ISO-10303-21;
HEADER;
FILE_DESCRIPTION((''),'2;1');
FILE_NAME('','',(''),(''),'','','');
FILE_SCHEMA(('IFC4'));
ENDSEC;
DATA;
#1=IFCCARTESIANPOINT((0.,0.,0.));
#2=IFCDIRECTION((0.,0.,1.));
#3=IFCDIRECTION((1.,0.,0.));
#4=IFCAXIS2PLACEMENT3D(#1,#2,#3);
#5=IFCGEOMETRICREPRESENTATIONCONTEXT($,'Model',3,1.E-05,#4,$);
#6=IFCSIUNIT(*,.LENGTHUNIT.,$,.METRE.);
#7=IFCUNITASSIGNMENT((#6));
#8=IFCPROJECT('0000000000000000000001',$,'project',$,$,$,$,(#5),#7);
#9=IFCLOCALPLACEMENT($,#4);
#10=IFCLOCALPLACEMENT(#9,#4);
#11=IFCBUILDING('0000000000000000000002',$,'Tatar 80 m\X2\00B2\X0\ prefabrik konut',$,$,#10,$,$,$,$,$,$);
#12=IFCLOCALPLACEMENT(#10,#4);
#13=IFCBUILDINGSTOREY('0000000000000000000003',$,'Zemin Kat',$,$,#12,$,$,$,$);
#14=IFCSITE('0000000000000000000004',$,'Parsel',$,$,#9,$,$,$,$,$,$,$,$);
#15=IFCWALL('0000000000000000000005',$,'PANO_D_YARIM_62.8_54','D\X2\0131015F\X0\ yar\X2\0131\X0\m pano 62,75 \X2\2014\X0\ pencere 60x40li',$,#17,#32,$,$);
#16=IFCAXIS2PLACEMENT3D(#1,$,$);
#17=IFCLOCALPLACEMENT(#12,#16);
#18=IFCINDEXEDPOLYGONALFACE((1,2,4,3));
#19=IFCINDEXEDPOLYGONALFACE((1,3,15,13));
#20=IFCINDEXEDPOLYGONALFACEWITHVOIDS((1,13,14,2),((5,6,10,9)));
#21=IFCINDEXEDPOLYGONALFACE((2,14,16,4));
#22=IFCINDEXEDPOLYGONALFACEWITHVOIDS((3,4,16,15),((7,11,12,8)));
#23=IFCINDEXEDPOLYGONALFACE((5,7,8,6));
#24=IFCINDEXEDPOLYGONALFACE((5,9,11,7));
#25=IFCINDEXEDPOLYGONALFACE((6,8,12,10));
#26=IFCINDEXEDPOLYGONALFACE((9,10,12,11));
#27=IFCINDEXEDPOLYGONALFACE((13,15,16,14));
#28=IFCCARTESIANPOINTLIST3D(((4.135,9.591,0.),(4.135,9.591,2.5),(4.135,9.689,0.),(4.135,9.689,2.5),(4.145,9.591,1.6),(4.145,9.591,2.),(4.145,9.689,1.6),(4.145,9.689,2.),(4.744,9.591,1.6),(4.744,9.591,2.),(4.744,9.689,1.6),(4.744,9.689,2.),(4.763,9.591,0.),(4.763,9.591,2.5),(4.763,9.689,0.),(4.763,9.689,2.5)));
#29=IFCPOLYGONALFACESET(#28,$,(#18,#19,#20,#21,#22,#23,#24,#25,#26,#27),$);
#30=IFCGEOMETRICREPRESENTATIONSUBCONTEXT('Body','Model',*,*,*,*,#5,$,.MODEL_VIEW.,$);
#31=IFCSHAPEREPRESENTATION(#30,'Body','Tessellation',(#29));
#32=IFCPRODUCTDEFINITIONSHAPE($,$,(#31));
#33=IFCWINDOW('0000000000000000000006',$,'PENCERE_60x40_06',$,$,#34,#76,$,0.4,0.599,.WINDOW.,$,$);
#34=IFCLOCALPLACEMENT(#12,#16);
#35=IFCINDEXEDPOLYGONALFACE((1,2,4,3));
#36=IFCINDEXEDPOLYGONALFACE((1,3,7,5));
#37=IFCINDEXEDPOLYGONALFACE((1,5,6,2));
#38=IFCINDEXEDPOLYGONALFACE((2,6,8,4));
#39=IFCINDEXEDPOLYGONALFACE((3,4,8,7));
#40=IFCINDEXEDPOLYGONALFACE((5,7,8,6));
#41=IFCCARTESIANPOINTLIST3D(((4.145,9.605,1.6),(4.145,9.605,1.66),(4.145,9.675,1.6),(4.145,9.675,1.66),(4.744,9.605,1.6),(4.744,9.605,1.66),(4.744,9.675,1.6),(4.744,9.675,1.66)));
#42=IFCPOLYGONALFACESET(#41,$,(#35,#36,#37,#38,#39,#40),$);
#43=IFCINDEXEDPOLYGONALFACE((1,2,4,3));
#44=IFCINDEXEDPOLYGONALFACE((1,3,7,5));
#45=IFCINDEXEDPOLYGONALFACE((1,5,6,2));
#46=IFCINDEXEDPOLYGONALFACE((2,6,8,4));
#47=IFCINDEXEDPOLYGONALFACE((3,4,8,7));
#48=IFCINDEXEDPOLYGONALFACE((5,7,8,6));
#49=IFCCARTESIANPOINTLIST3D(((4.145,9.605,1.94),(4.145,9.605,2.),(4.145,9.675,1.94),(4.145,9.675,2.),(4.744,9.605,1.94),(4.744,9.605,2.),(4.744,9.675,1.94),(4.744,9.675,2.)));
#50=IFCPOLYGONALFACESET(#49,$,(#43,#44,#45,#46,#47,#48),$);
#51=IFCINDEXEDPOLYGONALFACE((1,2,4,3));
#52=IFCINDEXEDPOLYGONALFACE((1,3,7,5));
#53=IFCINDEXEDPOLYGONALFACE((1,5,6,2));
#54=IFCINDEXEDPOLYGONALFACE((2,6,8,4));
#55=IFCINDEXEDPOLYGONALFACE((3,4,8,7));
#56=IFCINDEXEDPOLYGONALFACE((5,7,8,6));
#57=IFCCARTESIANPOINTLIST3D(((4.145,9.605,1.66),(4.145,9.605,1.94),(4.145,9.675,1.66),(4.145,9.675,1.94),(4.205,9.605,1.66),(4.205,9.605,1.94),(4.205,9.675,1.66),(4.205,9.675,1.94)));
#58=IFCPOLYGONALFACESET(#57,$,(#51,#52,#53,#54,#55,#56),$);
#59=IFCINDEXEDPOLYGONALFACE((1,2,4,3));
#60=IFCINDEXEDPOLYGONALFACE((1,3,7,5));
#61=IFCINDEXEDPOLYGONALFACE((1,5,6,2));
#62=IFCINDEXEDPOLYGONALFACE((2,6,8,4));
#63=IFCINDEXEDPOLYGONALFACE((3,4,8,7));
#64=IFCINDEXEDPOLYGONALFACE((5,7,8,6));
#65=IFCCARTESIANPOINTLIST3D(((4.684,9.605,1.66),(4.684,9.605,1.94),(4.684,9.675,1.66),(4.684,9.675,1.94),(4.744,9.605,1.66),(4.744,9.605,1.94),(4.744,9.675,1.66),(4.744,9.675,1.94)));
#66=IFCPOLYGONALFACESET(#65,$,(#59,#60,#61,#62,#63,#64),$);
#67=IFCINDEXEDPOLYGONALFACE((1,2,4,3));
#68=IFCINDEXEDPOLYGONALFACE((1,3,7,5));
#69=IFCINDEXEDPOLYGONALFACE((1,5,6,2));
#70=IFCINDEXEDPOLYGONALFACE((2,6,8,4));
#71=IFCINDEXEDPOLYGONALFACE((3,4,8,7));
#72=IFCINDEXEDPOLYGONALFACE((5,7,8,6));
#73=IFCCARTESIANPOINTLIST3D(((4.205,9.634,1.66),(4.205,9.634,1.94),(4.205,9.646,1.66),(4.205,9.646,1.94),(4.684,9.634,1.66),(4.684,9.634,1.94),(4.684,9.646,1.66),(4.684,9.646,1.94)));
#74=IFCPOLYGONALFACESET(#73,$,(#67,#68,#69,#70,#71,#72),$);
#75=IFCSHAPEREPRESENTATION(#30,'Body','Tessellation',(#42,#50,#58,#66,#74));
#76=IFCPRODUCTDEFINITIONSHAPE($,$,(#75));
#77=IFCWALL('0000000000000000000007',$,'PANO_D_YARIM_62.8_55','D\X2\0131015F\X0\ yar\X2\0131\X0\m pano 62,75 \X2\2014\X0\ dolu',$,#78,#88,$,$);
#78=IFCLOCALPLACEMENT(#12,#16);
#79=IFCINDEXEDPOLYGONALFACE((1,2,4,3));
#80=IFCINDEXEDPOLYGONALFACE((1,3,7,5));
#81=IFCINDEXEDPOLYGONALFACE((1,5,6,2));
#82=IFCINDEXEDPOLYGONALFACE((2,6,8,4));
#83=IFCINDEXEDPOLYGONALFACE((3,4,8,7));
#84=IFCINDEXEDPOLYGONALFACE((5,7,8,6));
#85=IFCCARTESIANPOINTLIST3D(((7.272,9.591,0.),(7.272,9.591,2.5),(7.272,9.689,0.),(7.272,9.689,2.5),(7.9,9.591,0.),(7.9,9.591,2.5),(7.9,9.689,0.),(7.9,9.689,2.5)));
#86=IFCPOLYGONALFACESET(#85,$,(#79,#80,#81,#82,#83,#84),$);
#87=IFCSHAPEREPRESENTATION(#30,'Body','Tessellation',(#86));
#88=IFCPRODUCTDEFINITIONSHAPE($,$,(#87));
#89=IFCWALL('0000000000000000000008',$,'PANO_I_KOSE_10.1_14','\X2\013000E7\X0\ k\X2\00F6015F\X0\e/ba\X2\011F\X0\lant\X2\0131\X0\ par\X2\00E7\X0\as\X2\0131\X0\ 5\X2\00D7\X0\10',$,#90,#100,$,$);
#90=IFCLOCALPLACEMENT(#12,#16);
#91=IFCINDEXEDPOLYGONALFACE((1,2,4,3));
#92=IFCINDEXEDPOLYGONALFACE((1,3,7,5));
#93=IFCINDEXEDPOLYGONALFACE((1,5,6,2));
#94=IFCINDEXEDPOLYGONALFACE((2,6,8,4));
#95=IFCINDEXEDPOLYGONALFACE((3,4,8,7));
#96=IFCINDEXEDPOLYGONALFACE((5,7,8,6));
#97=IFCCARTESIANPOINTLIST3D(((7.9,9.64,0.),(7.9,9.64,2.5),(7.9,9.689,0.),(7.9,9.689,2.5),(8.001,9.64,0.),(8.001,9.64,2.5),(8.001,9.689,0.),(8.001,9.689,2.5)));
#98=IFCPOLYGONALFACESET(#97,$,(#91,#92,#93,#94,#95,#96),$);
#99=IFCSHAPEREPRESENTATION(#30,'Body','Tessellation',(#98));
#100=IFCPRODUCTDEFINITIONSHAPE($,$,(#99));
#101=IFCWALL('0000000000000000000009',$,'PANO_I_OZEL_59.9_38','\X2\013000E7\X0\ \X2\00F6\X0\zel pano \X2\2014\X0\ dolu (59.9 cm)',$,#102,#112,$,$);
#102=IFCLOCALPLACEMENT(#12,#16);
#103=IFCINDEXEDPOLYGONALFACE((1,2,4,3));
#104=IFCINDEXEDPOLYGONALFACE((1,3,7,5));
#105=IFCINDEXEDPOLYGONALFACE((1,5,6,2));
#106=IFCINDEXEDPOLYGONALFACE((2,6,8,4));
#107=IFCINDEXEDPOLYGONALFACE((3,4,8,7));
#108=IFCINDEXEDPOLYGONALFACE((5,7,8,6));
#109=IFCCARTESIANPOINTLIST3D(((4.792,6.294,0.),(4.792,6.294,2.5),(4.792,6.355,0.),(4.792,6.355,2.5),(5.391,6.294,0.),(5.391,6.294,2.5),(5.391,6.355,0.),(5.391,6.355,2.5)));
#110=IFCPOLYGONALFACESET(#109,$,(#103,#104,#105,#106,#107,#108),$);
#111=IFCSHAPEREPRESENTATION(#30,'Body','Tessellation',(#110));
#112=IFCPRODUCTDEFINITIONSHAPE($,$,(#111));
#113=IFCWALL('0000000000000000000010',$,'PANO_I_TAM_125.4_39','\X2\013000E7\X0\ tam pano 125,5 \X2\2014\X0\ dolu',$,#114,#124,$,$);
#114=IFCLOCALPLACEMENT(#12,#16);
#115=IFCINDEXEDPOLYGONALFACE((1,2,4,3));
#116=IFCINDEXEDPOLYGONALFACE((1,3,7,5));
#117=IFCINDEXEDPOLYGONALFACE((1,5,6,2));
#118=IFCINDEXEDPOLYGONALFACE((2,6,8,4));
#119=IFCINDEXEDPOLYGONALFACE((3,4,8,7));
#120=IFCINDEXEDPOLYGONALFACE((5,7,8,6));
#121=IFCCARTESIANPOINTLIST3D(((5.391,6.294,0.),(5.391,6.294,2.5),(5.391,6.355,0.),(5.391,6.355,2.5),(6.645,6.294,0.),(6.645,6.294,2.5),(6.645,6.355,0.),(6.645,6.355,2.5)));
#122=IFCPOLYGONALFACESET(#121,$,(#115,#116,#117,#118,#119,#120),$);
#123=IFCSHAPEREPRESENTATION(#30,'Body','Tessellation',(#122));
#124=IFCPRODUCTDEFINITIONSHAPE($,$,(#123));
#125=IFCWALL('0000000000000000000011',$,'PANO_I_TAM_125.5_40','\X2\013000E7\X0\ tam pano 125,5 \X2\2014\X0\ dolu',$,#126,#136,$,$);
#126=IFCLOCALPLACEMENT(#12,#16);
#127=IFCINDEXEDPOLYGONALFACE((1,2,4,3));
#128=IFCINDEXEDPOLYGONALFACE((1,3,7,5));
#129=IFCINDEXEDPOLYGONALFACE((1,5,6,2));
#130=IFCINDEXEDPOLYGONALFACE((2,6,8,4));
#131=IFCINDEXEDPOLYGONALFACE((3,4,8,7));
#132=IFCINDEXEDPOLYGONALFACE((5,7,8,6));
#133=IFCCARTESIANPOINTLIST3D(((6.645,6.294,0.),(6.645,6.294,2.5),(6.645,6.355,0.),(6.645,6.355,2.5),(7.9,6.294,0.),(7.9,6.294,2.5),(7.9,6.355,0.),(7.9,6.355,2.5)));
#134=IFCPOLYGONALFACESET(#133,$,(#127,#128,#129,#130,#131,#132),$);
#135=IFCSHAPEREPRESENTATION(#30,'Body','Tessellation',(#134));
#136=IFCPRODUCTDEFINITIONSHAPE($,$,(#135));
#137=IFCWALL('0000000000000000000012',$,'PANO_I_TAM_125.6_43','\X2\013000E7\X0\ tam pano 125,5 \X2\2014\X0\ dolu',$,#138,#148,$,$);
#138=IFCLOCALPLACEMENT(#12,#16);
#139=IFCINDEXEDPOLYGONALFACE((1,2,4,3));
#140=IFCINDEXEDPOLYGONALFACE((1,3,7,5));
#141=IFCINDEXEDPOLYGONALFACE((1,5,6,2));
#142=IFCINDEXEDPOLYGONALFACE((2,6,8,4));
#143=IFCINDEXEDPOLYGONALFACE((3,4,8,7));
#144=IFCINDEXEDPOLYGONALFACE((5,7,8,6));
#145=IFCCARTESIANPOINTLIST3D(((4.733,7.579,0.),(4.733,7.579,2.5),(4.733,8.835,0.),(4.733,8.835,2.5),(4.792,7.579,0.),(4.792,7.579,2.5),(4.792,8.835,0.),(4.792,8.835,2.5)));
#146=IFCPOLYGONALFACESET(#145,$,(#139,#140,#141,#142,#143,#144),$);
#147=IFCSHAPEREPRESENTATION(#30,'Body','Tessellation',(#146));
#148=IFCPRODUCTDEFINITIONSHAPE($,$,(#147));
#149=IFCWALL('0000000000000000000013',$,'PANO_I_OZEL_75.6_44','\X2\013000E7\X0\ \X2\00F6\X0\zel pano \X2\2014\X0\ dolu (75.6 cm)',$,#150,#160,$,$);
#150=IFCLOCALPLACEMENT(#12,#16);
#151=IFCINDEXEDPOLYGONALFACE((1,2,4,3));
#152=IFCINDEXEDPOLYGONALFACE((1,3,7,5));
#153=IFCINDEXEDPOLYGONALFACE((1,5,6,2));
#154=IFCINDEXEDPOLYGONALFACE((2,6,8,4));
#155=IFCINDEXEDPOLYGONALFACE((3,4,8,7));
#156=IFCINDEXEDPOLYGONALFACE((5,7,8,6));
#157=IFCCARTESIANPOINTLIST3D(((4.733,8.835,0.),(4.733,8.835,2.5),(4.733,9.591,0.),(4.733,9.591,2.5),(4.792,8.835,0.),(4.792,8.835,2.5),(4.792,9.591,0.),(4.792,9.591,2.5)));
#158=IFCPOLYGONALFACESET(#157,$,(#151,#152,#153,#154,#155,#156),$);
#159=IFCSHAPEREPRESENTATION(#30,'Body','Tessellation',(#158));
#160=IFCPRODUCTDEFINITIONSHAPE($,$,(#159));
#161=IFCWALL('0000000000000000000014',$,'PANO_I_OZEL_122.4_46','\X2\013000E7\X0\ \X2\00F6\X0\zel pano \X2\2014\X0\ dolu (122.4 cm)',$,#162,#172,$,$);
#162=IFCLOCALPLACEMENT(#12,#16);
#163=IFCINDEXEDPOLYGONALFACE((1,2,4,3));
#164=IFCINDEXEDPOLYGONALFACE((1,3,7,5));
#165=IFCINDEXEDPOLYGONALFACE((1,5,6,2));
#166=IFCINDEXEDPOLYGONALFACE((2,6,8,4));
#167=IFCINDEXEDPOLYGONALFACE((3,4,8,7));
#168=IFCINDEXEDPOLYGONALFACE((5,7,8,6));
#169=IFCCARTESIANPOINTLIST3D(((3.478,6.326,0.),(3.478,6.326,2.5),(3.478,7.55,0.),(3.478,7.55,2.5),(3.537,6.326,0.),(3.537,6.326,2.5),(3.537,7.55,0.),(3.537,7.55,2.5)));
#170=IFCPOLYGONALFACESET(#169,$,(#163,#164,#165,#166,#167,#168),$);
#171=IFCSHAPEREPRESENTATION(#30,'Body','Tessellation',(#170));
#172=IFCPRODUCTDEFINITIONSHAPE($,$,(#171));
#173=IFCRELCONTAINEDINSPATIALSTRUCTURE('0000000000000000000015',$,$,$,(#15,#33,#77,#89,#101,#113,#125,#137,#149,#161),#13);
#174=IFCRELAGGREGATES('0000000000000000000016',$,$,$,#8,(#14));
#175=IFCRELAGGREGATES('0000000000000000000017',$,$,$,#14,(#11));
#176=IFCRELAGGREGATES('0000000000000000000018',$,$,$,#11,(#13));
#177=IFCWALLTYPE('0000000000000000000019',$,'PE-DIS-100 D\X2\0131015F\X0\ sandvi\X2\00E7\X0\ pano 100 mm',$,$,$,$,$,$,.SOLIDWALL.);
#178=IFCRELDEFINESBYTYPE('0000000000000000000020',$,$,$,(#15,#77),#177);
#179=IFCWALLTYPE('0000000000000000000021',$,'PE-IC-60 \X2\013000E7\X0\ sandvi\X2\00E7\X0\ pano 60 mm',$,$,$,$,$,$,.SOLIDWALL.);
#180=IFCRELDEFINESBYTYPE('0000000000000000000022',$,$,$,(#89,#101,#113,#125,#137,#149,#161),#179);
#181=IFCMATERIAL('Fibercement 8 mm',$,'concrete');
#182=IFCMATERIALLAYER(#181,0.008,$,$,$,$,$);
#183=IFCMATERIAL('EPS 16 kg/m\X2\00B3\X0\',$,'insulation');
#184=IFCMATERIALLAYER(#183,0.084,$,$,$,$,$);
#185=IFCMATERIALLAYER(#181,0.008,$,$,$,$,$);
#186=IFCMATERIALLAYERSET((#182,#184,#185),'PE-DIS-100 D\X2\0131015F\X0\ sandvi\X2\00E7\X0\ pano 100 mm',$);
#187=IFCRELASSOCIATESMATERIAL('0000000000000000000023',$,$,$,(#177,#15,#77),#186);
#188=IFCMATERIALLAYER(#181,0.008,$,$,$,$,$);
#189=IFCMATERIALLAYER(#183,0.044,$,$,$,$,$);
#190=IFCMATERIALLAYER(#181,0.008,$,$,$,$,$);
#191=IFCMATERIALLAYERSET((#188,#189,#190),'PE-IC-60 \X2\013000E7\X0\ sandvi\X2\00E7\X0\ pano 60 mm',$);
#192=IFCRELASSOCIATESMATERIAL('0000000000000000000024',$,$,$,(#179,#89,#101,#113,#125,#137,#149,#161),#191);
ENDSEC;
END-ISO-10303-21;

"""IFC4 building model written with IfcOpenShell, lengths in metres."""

from ifc_helpers import new_model, si_unit, frame, origin_with_axes, place, context, subcontext, project, spatial, line, indexed_curve, outline, extrude, material, layer, layer_set, layer_usage, type_object, element, fill, save


model = new_model("IFC4")

# Units and contexts
model_context = context("Model", 3, precision=1e-05, world=origin_with_axes())
body_context = subcontext(model_context, "Body", "Model", "MODEL_VIEW")
ifc_project = project(units=[si_unit("LENGTHUNIT", "METRE")], contexts=[model_context])

# Site, building, storey
site_placement = place(None, origin_with_axes())
site = spatial("IfcSite", under=ifc_project, at=site_placement, Name="Parsel")
building_placement = place(site_placement, origin_with_axes())
building = spatial("IfcBuilding", under=site, at=building_placement, Name="Tatar 80 m² prefabrik konut")
storey_placement = place(building_placement, origin_with_axes())
storey = spatial("IfcBuildingStorey", under=building, at=storey_placement, Name="Zemin Kat")

# Shared definitions
ifc_material_1 = material(Name="Fibercement 8 mm", Category="concrete")
ifc_layer_1 = layer(ifc_material_1, 0.008)
ifc_material_2 = material(Name="EPS 16 kg/m³", Category="insulation")
ifc_layer_2 = layer(ifc_material_2, 0.084)
ifc_layer_3 = layer(ifc_material_1, 0.008)
ifc_layer_set_1 = layer_set([ifc_layer_1, ifc_layer_2, ifc_layer_3], Name="PE-DIS-100 Dış sandviç pano 100 mm")
wall_type_1 = type_object("IfcWallType", Name="PE-DIS-100 Dış sandviç pano 100 mm", PredefinedType="SOLIDWALL", material=ifc_layer_set_1)

# Wall, opening, window
ifc_layer_usage_1 = layer_usage(ifc_layer_set_1, "AXIS2", "POSITIVE", 0.0)
wall_1_placement = place(storey_placement, frame((4.135, 9.591, 0.0), z_axis=(0.0, 0.0, 1.0), x_axis=(1.0, 0.0, 0.0)))
wall_1 = element("IfcWall", 1, at=wall_1_placement, inside=storey, type_object=wall_type_1, material=ifc_layer_usage_1, Name="PANO_D_YARIM_62.8_54", Description="Dış yarım pano 62,75 — pencere 60x40li", context=body_context, shape_type="SweptSolid", body=[
    extrude(outline(indexed_curve([(0.0, 0.0), (0.628, 0.0), (0.628, 0.098), (0.0, 0.098)], segments=[line(1, 2, 3, 4, 1)])), origin_with_axes(), (0.0, 0.0, 1.0), 2.5),
])
opening_1_placement = place(wall_1_placement, origin_with_axes())
opening_1 = element("IfcOpeningElement", 2, at=opening_1_placement, cuts=wall_1, PredefinedType="OPENING", context=body_context, shape_type="SweptSolid", body=[
    extrude(outline(indexed_curve([(0.0, 0.0), (0.599, 0.0), (0.599, 0.138), (0.0, 0.138)], segments=[line(1, 2, 3, 4, 1)])), frame((0.01, -0.02, 1.6), z_axis=(0.0, 0.0, 1.0), x_axis=(1.0, 0.0, 0.0)), (0.0, 0.0, 1.0), 0.4),
])
window_1_placement = place(storey_placement, frame((4.135, 9.591, 0.0), z_axis=(0.0, 0.0, 1.0), x_axis=(1.0, 0.0, 0.0)))
window_1 = element("IfcWindow", 3, at=window_1_placement, inside=storey, Name="PENCERE_60x40_06", OverallHeight=0.4, OverallWidth=0.599, PredefinedType="WINDOW", context=body_context, shape_type="SweptSolid", body=[
    extrude(outline(indexed_curve([(0.0, 0.0), (0.599, 0.0), (0.599, 0.07), (0.0, 0.07)], segments=[line(1, 2, 3, 4, 1)])), frame((0.01, 0.014, 1.6), z_axis=(0.0, 0.0, 1.0), x_axis=(1.0, 0.0, 0.0)), (0.0, 0.0, 1.0), 0.06),
    extrude(outline(indexed_curve([(0.0, 0.0), (0.599, 0.0), (0.599, 0.07), (0.0, 0.07)], segments=[line(1, 2, 3, 4, 1)])), frame((0.01, 0.014, 1.94), z_axis=(0.0, 0.0, 1.0), x_axis=(1.0, 0.0, 0.0)), (0.0, 0.0, 1.0), 0.06),
    extrude(outline(indexed_curve([(0.0, 0.0), (0.06, 0.0), (0.06, 0.07), (0.0, 0.07)], segments=[line(1, 2, 3, 4, 1)])), frame((0.01, 0.014, 1.66), z_axis=(0.0, 0.0, 1.0), x_axis=(1.0, 0.0, 0.0)), (0.0, 0.0, 1.0), 0.28),
    extrude(outline(indexed_curve([(0.0, 0.0), (0.06, 0.0), (0.06, 0.07), (0.0, 0.07)], segments=[line(1, 2, 3, 4, 1)])), frame((0.549, 0.014, 1.66), z_axis=(0.0, 0.0, 1.0), x_axis=(1.0, 0.0, 0.0)), (0.0, 0.0, 1.0), 0.28),
    extrude(outline(indexed_curve([(0.0, 0.0), (0.479, 0.0), (0.479, 0.012), (0.0, 0.012)], segments=[line(1, 2, 3, 4, 1)])), frame((0.07, 0.043, 1.66), z_axis=(0.0, 0.0, 1.0), x_axis=(1.0, 0.0, 0.0)), (0.0, 0.0, 1.0), 0.28),
])
fill(opening_1, window_1)

# Walls
ifc_layer_usage_2 = layer_usage(ifc_layer_set_1, "AXIS2", "POSITIVE", 0.0)
wall_2_placement = place(storey_placement, frame((7.272, 9.591, 0.0), z_axis=(0.0, 0.0, 1.0), x_axis=(1.0, 0.0, 0.0)))
element("IfcWall", 4, at=wall_2_placement, inside=storey, type_object=wall_type_1, material=ifc_layer_usage_2, Name="PANO_D_YARIM_62.8_55", Description="Dış yarım pano 62,75 — dolu", context=body_context, shape_type="SweptSolid", body=[
    extrude(outline(indexed_curve([(0.0, 0.0), (0.628, 0.0), (0.628, 0.098), (0.0, 0.098)], segments=[line(1, 2, 3, 4, 1)])), origin_with_axes(), (0.0, 0.0, 1.0), 2.5),
])
ifc_layer_4 = layer(ifc_material_1, 0.008)
ifc_layer_5 = layer(ifc_material_2, 0.044)
ifc_layer_6 = layer(ifc_material_1, 0.008)
ifc_layer_set_2 = layer_set([ifc_layer_4, ifc_layer_5, ifc_layer_6], Name="PE-IC-60 İç sandviç pano 60 mm")
ifc_layer_usage_3 = layer_usage(ifc_layer_set_2, "AXIS2", "POSITIVE", 0.0)
wall_type_2 = type_object("IfcWallType", Name="PE-IC-60 İç sandviç pano 60 mm", PredefinedType="SOLIDWALL", material=ifc_layer_set_2)
wall_3_placement = place(storey_placement, frame((7.9, 9.64, 0.0), z_axis=(0.0, 0.0, 1.0), x_axis=(1.0, 0.0, 0.0)))
element("IfcWall", 5, at=wall_3_placement, inside=storey, type_object=wall_type_2, material=ifc_layer_usage_3, Name="PANO_I_KOSE_10.1_14", Description="İç köşe/bağlantı parçası 5×10", context=body_context, shape_type="SweptSolid", body=[
    extrude(outline(indexed_curve([(0.0, 0.0), (0.101, 0.0), (0.101, 0.049), (0.0, 0.049)], segments=[line(1, 2, 3, 4, 1)])), origin_with_axes(), (0.0, 0.0, 1.0), 2.5),
])
ifc_layer_usage_4 = layer_usage(ifc_layer_set_2, "AXIS2", "POSITIVE", 0.0)
wall_4_placement = place(storey_placement, frame((4.792, 6.294, 0.0), z_axis=(0.0, 0.0, 1.0), x_axis=(1.0, 0.0, 0.0)))
element("IfcWall", 6, at=wall_4_placement, inside=storey, type_object=wall_type_2, material=ifc_layer_usage_4, Name="PANO_I_OZEL_59.9_38", Description="İç özel pano — dolu (59.9 cm)", context=body_context, shape_type="SweptSolid", body=[
    extrude(outline(indexed_curve([(0.0, 0.0), (0.599, 0.0), (0.599, 0.061), (0.0, 0.061)], segments=[line(1, 2, 3, 4, 1)])), origin_with_axes(), (0.0, 0.0, 1.0), 2.5),
])
ifc_layer_usage_5 = layer_usage(ifc_layer_set_2, "AXIS2", "POSITIVE", 0.0)
wall_5_placement = place(storey_placement, frame((5.391, 6.294, 0.0), z_axis=(0.0, 0.0, 1.0), x_axis=(1.0, 0.0, 0.0)))
element("IfcWall", 7, at=wall_5_placement, inside=storey, type_object=wall_type_2, material=ifc_layer_usage_5, Name="PANO_I_TAM_125.4_39", Description="İç tam pano 125,5 — dolu", context=body_context, shape_type="SweptSolid", body=[
    extrude(outline(indexed_curve([(0.0, 0.0), (1.254, 0.0), (1.254, 0.061), (0.0, 0.061)], segments=[line(1, 2, 3, 4, 1)])), origin_with_axes(), (0.0, 0.0, 1.0), 2.5),
])
ifc_layer_usage_6 = layer_usage(ifc_layer_set_2, "AXIS2", "POSITIVE", 0.0)
wall_6_placement = place(storey_placement, frame((6.645, 6.294, 0.0), z_axis=(0.0, 0.0, 1.0), x_axis=(1.0, 0.0, 0.0)))
element("IfcWall", 8, at=wall_6_placement, inside=storey, type_object=wall_type_2, material=ifc_layer_usage_6, Name="PANO_I_TAM_125.5_40", Description="İç tam pano 125,5 — dolu", context=body_context, shape_type="SweptSolid", body=[
    extrude(outline(indexed_curve([(0.0, 0.0), (1.255, 0.0), (1.255, 0.061), (0.0, 0.061)], segments=[line(1, 2, 3, 4, 1)])), origin_with_axes(), (0.0, 0.0, 1.0), 2.5),
])
ifc_layer_usage_7 = layer_usage(ifc_layer_set_2, "AXIS2", "POSITIVE", 0.0)
wall_7_placement = place(storey_placement, frame((4.792, 7.579, 0.0), z_axis=(0.0, 0.0, 1.0), x_axis=(0.0, 1.0, 0.0)))
element("IfcWall", 9, at=wall_7_placement, inside=storey, type_object=wall_type_2, material=ifc_layer_usage_7, Name="PANO_I_TAM_125.6_43", Description="İç tam pano 125,5 — dolu", context=body_context, shape_type="SweptSolid", body=[
    extrude(outline(indexed_curve([(0.0, 0.0), (1.256, 0.0), (1.256, 0.059), (0.0, 0.059)], segments=[line(1, 2, 3, 4, 1)])), origin_with_axes(), (0.0, 0.0, 1.0), 2.5),
])
ifc_layer_usage_8 = layer_usage(ifc_layer_set_2, "AXIS2", "POSITIVE", 0.0)
wall_8_placement = place(storey_placement, frame((4.792, 8.835, 0.0), z_axis=(0.0, 0.0, 1.0), x_axis=(0.0, 1.0, 0.0)))
element("IfcWall", 10, at=wall_8_placement, inside=storey, type_object=wall_type_2, material=ifc_layer_usage_8, Name="PANO_I_OZEL_75.6_44", Description="İç özel pano — dolu (75.6 cm)", context=body_context, shape_type="SweptSolid", body=[
    extrude(outline(indexed_curve([(0.0, 0.0), (0.756, 0.0), (0.756, 0.059), (0.0, 0.059)], segments=[line(1, 2, 3, 4, 1)])), origin_with_axes(), (0.0, 0.0, 1.0), 2.5),
])
ifc_layer_usage_9 = layer_usage(ifc_layer_set_2, "AXIS2", "POSITIVE", 0.0)
wall_9_placement = place(storey_placement, frame((3.537, 6.326, 0.0), z_axis=(0.0, 0.0, 1.0), x_axis=(0.0, 1.0, 0.0)))
element("IfcWall", 11, at=wall_9_placement, inside=storey, type_object=wall_type_2, material=ifc_layer_usage_9, Name="PANO_I_OZEL_122.4_46", Description="İç özel pano — dolu (122.4 cm)", context=body_context, shape_type="SweptSolid", body=[
    extrude(outline(indexed_curve([(0.0, 0.0), (1.224, 0.0), (1.224, 0.059), (0.0, 0.059)], segments=[line(1, 2, 3, 4, 1)])), origin_with_axes(), (0.0, 0.0, 1.0), 2.5),
])

save(model, "model.ifc")
